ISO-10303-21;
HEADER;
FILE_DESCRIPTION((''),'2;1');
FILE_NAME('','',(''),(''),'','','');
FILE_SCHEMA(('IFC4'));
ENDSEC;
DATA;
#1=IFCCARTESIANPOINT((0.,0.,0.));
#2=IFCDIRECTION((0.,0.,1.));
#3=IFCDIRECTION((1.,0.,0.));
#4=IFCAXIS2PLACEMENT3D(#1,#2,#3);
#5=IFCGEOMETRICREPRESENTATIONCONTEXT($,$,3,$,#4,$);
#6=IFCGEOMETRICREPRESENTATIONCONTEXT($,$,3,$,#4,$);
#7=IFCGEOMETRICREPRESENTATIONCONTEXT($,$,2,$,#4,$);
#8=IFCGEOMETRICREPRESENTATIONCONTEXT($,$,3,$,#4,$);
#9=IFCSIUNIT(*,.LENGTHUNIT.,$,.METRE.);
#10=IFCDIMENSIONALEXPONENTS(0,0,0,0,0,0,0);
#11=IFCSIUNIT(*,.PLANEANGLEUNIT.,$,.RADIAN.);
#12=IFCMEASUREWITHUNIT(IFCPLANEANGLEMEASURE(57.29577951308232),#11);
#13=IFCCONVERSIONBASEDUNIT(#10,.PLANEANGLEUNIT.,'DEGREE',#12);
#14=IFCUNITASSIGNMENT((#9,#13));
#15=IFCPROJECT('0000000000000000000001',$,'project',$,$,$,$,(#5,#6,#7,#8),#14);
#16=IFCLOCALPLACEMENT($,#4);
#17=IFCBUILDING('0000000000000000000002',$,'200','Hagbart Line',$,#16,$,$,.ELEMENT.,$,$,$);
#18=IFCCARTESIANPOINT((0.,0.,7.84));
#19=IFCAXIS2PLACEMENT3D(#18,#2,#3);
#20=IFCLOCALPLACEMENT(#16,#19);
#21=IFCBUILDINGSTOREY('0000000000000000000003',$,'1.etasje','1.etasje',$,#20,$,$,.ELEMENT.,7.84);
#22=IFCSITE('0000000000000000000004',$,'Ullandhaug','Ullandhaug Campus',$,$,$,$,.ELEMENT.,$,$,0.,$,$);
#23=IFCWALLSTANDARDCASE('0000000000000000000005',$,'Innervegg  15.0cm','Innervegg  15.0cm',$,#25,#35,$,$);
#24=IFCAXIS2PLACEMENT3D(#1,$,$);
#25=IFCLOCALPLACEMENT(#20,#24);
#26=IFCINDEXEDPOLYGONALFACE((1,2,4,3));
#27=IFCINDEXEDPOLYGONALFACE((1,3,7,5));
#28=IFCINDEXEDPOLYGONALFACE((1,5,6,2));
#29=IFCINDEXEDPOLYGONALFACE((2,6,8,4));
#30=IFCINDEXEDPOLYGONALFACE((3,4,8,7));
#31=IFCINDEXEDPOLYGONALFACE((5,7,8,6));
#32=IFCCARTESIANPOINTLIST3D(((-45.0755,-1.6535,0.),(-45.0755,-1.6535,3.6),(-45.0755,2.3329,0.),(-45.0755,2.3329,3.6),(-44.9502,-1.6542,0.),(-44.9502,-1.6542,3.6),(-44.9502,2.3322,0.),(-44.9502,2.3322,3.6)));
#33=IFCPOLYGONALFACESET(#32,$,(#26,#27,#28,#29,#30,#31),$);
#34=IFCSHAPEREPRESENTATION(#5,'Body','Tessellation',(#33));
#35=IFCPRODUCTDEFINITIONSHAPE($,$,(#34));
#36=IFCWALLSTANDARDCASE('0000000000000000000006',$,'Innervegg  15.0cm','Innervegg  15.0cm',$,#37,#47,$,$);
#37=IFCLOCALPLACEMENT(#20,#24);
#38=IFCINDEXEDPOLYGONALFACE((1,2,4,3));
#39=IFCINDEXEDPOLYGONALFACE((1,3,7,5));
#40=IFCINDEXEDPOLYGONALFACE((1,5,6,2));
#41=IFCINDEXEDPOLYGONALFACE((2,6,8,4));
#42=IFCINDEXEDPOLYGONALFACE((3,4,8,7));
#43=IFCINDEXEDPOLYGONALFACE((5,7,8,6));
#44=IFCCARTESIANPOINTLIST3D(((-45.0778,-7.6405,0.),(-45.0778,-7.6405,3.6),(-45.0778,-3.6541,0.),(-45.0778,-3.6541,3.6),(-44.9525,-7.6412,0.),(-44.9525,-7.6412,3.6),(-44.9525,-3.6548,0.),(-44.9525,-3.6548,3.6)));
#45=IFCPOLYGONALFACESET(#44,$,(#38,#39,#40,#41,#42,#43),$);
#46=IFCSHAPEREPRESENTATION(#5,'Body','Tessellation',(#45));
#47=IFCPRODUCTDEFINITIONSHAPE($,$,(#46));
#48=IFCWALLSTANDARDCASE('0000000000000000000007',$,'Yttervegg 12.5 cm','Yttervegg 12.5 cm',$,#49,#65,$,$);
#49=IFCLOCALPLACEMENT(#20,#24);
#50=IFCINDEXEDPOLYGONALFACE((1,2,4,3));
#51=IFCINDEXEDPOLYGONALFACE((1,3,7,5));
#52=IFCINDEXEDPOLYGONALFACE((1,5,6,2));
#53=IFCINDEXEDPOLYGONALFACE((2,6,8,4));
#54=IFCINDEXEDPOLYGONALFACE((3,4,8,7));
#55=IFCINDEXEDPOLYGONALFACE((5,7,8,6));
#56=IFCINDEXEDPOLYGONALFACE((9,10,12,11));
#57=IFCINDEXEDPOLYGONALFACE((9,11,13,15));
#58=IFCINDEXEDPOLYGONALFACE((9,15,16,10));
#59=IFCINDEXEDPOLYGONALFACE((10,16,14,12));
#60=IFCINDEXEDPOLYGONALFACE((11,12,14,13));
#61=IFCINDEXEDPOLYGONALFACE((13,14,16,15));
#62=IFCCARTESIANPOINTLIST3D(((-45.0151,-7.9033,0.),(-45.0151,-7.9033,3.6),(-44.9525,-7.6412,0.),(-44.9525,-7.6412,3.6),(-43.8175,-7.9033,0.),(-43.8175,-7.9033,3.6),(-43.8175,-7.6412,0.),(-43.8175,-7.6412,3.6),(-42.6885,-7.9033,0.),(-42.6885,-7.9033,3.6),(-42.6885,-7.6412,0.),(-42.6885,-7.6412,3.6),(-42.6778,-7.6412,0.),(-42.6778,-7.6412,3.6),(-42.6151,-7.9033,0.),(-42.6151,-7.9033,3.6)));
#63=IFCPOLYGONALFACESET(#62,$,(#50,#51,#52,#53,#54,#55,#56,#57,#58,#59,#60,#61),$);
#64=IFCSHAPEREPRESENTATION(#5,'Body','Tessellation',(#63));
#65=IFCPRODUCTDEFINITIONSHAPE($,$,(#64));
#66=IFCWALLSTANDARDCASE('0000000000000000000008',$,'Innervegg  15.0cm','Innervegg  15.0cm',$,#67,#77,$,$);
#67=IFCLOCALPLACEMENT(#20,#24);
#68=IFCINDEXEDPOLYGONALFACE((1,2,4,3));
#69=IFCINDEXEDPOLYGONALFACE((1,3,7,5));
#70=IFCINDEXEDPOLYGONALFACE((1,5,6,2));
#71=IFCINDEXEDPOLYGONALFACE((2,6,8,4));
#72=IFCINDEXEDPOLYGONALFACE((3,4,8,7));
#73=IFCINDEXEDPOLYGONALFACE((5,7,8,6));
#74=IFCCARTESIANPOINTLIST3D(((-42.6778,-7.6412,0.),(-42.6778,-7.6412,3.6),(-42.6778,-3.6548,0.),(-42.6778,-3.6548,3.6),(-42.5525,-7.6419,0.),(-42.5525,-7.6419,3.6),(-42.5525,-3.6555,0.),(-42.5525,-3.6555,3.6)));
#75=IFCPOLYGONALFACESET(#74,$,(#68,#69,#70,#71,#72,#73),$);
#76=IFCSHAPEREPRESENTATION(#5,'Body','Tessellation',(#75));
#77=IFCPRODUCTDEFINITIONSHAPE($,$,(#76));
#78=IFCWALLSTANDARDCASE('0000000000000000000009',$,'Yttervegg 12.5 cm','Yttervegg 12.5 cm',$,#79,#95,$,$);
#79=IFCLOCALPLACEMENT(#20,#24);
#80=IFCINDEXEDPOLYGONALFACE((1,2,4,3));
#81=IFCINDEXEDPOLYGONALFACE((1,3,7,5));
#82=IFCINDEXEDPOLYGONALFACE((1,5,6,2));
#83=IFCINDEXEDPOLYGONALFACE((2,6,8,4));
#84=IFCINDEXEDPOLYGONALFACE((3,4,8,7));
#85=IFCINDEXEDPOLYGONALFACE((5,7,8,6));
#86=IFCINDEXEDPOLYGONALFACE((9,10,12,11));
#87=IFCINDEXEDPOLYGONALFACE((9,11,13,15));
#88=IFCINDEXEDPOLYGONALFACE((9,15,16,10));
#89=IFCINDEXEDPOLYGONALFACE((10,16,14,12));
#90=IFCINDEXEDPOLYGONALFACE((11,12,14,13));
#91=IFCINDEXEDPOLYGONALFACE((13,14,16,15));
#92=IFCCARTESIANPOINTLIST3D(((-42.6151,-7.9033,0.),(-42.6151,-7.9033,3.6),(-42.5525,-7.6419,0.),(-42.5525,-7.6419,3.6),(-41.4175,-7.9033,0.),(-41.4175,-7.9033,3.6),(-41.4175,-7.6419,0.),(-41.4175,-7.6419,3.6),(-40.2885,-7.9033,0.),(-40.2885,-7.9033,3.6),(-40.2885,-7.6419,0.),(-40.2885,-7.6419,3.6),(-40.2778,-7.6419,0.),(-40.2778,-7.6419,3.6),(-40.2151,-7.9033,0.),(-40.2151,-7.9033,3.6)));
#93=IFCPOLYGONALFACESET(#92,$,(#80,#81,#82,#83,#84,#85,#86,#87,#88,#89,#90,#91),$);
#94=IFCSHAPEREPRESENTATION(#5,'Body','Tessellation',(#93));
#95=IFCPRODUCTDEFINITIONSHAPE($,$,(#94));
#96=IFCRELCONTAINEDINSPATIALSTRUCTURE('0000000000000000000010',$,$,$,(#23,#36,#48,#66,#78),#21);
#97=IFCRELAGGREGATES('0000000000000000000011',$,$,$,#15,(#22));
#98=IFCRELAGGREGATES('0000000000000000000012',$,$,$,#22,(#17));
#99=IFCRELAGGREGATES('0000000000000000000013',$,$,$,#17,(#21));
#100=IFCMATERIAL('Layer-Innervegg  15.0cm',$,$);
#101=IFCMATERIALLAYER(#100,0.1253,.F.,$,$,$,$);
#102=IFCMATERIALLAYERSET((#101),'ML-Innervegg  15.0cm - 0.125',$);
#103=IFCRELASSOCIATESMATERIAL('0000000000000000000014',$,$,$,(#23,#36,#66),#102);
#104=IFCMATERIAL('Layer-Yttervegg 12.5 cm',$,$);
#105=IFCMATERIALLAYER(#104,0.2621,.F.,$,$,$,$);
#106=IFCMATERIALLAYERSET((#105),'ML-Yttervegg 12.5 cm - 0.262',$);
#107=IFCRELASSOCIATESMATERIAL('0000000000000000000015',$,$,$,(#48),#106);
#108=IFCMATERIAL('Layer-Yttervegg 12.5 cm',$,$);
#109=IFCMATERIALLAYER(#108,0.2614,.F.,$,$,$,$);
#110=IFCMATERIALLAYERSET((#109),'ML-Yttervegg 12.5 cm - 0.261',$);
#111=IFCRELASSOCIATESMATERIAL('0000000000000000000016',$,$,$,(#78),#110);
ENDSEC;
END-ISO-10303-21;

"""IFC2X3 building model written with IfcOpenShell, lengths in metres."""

from ifc_helpers import new_model, entity, si_unit, converted_unit, frame, origin_with_axes, place, context, project, spatial, polyline, outline, extrude, material, layer, layer_set, layer_usage, element, save


model = new_model("IFC2X3")

# Units and contexts
context_of_model_1 = context(None, 3, world=origin_with_axes())
context_of_model_2 = context(None, 3, world=origin_with_axes())
context_of_model_3 = context(None, 2, world=origin_with_axes())
context_of_model_4 = context(None, 3, world=origin_with_axes())
ifc_project = project(units=[si_unit("LENGTHUNIT", "METRE"), converted_unit("PLANEANGLEUNIT", "DEGREE", entity("IfcPlaneAngleMeasure", 57.29577951308232), si_unit("PLANEANGLEUNIT", "RADIAN"), dimensions=[0, 0, 0, 0, 0, 0, 0])], contexts=[context_of_model_1, context_of_model_2, context_of_model_3, context_of_model_4])

# Site, building, storey
site = spatial("IfcSite", under=ifc_project, Name="Ullandhaug", Description="Ullandhaug Campus", CompositionType="ELEMENT", RefElevation=0.0)
building_placement = place(None, origin_with_axes())
building = spatial("IfcBuilding", under=site, at=building_placement, Name="200", Description="Hagbart Line", CompositionType="ELEMENT")
storey_placement = place(building_placement, frame((0.0, 0.0, 7.84), z_axis=(0.0, 0.0, 1.0), x_axis=(1.0, 0.0, 0.0)))
storey = spatial("IfcBuildingStorey", under=building, at=storey_placement, Name="1.etasje", Description="1.etasje", CompositionType="ELEMENT", Elevation=7.84)

# Walls
ifc_material_1 = material(Name="Layer-Innervegg  15.0cm")
ifc_layer_1 = layer(ifc_material_1, 0.1253, ventilated=False)
ifc_layer_set_1 = layer_set([ifc_layer_1], Name="ML-Innervegg  15.0cm - 0.125")
ifc_layer_usage_1 = layer_usage(ifc_layer_set_1, "AXIS2", "POSITIVE", 0.0)
wall_1_placement = place(storey_placement, frame((-44.9502, -1.6542, 0.0), z_axis=(0.0, 0.0, 1.0), x_axis=(0.0, 1.0, 0.0)))
element("IfcWallStandardCase", 1, at=wall_1_placement, inside=storey, material=ifc_layer_usage_1, Name="Innervegg  15.0cm", Description="Innervegg  15.0cm", context=context_of_model_1, shape_type="SweptSolid", body=[
    extrude(outline(polyline([(0.0, 0.0), (3.9863, 0.0), (3.987, 0.1253), (0.0007, 0.1253), (0.0, 0.0)])), frame((0.0, 0.0, 0.0), z_axis=(0.0, 0.0, 1.0), x_axis=(1.0, 0.0, 0.0)), (0.0, 0.0, 1.0), 3.6),
])
wall_2_placement = place(storey_placement, frame((-44.9525, -7.6412, 0.0), z_axis=(0.0, 0.0, 1.0), x_axis=(0.0, 1.0, 0.0)))
element("IfcWallStandardCase", 2, at=wall_2_placement, inside=storey, material=ifc_layer_usage_1, Name="Innervegg  15.0cm", Description="Innervegg  15.0cm", context=context_of_model_1, shape_type="SweptSolid", body=[
    extrude(outline(polyline([(0.0, 0.0), (3.9863, 0.0), (3.987, 0.1253), (0.0007, 0.1253), (0.0, 0.0)])), frame((0.0, 0.0, 0.0), z_axis=(0.0, 0.0, 1.0), x_axis=(1.0, 0.0, 0.0)), (0.0, 0.0, 1.0), 3.6),
])

# Wall, opening
ifc_material_2 = material(Name="Layer-Yttervegg 12.5 cm")
ifc_layer_2 = layer(ifc_material_2, 0.2621, ventilated=False)
ifc_layer_set_2 = layer_set([ifc_layer_2], Name="ML-Yttervegg 12.5 cm - 0.262")
ifc_layer_usage_2 = layer_usage(ifc_layer_set_2, "AXIS2", "POSITIVE", 0.0)
wall_3_placement = place(storey_placement, frame((-45.0151, -7.9033, 0.0), z_axis=(0.0, 0.0, 1.0), x_axis=(1.0, 0.0, 0.0)))
wall_3 = element("IfcWallStandardCase", 3, at=wall_3_placement, inside=storey, material=ifc_layer_usage_2, Name="Yttervegg 12.5 cm", Description="Yttervegg 12.5 cm", context=context_of_model_1, shape_type="SweptSolid", body=[
    extrude(outline(polyline([(0.0, 0.0), (2.4, 0.0), (2.3373, 0.2621), (0.0627, 0.2621), (0.0, 0.0)])), origin_with_axes(), (0.0, 0.0, 1.0), 3.6),
])
opening_1_placement = place(wall_3_placement, frame((1.1976, 0.2621, 0.0), z_axis=(0.0, 0.0, 1.0), x_axis=(1.0, 0.0, 0.0)))
element("IfcOpeningElement", 4, at=opening_1_placement, cuts=wall_3, context=context_of_model_1, shape_type="SweptSolid", body=[
    extrude(outline(polyline([(0.0, 0.0), (3.6, 0.0), (3.6, 1.129), (0.0, 1.129), (0.0, 0.0)])), frame((0.0, 0.0, 0.0), z_axis=(0.0, 1.0, 0.0), x_axis=(0.0, 0.0, 1.0)), (0.0, 0.0, -1.0), 0.2621),
])

# Wall
wall_4_placement = place(storey_placement, frame((-42.5525, -7.6419, 0.0), z_axis=(0.0, 0.0, 1.0), x_axis=(0.0, 1.0, 0.0)))
element("IfcWallStandardCase", 5, at=wall_4_placement, inside=storey, material=ifc_layer_usage_1, Name="Innervegg  15.0cm", Description="Innervegg  15.0cm", context=context_of_model_1, shape_type="SweptSolid", body=[
    extrude(outline(polyline([(0.0, 0.0), (3.9863, 0.0), (3.987, 0.1253), (0.0007, 0.1253), (0.0, 0.0)])), frame((0.0, 0.0, 0.0), z_axis=(0.0, 0.0, 1.0), x_axis=(1.0, 0.0, 0.0)), (0.0, 0.0, 1.0), 3.6),
])

# Wall, opening
ifc_material_3 = material(Name="Layer-Yttervegg 12.5 cm")
ifc_layer_3 = layer(ifc_material_3, 0.2614, ventilated=False)
ifc_layer_set_3 = layer_set([ifc_layer_3], Name="ML-Yttervegg 12.5 cm - 0.261")
ifc_layer_usage_3 = layer_usage(ifc_layer_set_3, "AXIS2", "POSITIVE", 0.0)
wall_5_placement = place(storey_placement, frame((-42.6151, -7.9033, 0.0), z_axis=(0.0, 0.0, 1.0), x_axis=(1.0, 0.0, 0.0)))
wall_5 = element("IfcWallStandardCase", 6, at=wall_5_placement, inside=storey, material=ifc_layer_usage_3, Name="Yttervegg 12.5 cm", Description="Yttervegg 12.5 cm", context=context_of_model_1, shape_type="SweptSolid", body=[
    extrude(outline(polyline([(0.0, 0.0), (2.4, 0.0), (2.3373, 0.2614), (0.0627, 0.2614), (0.0, 0.0)])), origin_with_axes(), (0.0, 0.0, 1.0), 3.6),
])
opening_2_placement = place(wall_5_placement, frame((1.1976, 0.2614, 0.0), z_axis=(0.0, 0.0, 1.0), x_axis=(1.0, 0.0, 0.0)))
element("IfcOpeningElement", 7, at=opening_2_placement, cuts=wall_5, context=context_of_model_1, shape_type="SweptSolid", body=[
    extrude(outline(polyline([(0.0, 0.0), (3.6, 0.0), (3.6, 1.129), (0.0, 1.129), (0.0, 0.0)])), frame((0.0, 0.0, 0.0), z_axis=(0.0, 1.0, 0.0), x_axis=(0.0, 0.0, 1.0)), (0.0, 0.0, -1.0), 0.2614),
])

save(model, "model.ifc")
